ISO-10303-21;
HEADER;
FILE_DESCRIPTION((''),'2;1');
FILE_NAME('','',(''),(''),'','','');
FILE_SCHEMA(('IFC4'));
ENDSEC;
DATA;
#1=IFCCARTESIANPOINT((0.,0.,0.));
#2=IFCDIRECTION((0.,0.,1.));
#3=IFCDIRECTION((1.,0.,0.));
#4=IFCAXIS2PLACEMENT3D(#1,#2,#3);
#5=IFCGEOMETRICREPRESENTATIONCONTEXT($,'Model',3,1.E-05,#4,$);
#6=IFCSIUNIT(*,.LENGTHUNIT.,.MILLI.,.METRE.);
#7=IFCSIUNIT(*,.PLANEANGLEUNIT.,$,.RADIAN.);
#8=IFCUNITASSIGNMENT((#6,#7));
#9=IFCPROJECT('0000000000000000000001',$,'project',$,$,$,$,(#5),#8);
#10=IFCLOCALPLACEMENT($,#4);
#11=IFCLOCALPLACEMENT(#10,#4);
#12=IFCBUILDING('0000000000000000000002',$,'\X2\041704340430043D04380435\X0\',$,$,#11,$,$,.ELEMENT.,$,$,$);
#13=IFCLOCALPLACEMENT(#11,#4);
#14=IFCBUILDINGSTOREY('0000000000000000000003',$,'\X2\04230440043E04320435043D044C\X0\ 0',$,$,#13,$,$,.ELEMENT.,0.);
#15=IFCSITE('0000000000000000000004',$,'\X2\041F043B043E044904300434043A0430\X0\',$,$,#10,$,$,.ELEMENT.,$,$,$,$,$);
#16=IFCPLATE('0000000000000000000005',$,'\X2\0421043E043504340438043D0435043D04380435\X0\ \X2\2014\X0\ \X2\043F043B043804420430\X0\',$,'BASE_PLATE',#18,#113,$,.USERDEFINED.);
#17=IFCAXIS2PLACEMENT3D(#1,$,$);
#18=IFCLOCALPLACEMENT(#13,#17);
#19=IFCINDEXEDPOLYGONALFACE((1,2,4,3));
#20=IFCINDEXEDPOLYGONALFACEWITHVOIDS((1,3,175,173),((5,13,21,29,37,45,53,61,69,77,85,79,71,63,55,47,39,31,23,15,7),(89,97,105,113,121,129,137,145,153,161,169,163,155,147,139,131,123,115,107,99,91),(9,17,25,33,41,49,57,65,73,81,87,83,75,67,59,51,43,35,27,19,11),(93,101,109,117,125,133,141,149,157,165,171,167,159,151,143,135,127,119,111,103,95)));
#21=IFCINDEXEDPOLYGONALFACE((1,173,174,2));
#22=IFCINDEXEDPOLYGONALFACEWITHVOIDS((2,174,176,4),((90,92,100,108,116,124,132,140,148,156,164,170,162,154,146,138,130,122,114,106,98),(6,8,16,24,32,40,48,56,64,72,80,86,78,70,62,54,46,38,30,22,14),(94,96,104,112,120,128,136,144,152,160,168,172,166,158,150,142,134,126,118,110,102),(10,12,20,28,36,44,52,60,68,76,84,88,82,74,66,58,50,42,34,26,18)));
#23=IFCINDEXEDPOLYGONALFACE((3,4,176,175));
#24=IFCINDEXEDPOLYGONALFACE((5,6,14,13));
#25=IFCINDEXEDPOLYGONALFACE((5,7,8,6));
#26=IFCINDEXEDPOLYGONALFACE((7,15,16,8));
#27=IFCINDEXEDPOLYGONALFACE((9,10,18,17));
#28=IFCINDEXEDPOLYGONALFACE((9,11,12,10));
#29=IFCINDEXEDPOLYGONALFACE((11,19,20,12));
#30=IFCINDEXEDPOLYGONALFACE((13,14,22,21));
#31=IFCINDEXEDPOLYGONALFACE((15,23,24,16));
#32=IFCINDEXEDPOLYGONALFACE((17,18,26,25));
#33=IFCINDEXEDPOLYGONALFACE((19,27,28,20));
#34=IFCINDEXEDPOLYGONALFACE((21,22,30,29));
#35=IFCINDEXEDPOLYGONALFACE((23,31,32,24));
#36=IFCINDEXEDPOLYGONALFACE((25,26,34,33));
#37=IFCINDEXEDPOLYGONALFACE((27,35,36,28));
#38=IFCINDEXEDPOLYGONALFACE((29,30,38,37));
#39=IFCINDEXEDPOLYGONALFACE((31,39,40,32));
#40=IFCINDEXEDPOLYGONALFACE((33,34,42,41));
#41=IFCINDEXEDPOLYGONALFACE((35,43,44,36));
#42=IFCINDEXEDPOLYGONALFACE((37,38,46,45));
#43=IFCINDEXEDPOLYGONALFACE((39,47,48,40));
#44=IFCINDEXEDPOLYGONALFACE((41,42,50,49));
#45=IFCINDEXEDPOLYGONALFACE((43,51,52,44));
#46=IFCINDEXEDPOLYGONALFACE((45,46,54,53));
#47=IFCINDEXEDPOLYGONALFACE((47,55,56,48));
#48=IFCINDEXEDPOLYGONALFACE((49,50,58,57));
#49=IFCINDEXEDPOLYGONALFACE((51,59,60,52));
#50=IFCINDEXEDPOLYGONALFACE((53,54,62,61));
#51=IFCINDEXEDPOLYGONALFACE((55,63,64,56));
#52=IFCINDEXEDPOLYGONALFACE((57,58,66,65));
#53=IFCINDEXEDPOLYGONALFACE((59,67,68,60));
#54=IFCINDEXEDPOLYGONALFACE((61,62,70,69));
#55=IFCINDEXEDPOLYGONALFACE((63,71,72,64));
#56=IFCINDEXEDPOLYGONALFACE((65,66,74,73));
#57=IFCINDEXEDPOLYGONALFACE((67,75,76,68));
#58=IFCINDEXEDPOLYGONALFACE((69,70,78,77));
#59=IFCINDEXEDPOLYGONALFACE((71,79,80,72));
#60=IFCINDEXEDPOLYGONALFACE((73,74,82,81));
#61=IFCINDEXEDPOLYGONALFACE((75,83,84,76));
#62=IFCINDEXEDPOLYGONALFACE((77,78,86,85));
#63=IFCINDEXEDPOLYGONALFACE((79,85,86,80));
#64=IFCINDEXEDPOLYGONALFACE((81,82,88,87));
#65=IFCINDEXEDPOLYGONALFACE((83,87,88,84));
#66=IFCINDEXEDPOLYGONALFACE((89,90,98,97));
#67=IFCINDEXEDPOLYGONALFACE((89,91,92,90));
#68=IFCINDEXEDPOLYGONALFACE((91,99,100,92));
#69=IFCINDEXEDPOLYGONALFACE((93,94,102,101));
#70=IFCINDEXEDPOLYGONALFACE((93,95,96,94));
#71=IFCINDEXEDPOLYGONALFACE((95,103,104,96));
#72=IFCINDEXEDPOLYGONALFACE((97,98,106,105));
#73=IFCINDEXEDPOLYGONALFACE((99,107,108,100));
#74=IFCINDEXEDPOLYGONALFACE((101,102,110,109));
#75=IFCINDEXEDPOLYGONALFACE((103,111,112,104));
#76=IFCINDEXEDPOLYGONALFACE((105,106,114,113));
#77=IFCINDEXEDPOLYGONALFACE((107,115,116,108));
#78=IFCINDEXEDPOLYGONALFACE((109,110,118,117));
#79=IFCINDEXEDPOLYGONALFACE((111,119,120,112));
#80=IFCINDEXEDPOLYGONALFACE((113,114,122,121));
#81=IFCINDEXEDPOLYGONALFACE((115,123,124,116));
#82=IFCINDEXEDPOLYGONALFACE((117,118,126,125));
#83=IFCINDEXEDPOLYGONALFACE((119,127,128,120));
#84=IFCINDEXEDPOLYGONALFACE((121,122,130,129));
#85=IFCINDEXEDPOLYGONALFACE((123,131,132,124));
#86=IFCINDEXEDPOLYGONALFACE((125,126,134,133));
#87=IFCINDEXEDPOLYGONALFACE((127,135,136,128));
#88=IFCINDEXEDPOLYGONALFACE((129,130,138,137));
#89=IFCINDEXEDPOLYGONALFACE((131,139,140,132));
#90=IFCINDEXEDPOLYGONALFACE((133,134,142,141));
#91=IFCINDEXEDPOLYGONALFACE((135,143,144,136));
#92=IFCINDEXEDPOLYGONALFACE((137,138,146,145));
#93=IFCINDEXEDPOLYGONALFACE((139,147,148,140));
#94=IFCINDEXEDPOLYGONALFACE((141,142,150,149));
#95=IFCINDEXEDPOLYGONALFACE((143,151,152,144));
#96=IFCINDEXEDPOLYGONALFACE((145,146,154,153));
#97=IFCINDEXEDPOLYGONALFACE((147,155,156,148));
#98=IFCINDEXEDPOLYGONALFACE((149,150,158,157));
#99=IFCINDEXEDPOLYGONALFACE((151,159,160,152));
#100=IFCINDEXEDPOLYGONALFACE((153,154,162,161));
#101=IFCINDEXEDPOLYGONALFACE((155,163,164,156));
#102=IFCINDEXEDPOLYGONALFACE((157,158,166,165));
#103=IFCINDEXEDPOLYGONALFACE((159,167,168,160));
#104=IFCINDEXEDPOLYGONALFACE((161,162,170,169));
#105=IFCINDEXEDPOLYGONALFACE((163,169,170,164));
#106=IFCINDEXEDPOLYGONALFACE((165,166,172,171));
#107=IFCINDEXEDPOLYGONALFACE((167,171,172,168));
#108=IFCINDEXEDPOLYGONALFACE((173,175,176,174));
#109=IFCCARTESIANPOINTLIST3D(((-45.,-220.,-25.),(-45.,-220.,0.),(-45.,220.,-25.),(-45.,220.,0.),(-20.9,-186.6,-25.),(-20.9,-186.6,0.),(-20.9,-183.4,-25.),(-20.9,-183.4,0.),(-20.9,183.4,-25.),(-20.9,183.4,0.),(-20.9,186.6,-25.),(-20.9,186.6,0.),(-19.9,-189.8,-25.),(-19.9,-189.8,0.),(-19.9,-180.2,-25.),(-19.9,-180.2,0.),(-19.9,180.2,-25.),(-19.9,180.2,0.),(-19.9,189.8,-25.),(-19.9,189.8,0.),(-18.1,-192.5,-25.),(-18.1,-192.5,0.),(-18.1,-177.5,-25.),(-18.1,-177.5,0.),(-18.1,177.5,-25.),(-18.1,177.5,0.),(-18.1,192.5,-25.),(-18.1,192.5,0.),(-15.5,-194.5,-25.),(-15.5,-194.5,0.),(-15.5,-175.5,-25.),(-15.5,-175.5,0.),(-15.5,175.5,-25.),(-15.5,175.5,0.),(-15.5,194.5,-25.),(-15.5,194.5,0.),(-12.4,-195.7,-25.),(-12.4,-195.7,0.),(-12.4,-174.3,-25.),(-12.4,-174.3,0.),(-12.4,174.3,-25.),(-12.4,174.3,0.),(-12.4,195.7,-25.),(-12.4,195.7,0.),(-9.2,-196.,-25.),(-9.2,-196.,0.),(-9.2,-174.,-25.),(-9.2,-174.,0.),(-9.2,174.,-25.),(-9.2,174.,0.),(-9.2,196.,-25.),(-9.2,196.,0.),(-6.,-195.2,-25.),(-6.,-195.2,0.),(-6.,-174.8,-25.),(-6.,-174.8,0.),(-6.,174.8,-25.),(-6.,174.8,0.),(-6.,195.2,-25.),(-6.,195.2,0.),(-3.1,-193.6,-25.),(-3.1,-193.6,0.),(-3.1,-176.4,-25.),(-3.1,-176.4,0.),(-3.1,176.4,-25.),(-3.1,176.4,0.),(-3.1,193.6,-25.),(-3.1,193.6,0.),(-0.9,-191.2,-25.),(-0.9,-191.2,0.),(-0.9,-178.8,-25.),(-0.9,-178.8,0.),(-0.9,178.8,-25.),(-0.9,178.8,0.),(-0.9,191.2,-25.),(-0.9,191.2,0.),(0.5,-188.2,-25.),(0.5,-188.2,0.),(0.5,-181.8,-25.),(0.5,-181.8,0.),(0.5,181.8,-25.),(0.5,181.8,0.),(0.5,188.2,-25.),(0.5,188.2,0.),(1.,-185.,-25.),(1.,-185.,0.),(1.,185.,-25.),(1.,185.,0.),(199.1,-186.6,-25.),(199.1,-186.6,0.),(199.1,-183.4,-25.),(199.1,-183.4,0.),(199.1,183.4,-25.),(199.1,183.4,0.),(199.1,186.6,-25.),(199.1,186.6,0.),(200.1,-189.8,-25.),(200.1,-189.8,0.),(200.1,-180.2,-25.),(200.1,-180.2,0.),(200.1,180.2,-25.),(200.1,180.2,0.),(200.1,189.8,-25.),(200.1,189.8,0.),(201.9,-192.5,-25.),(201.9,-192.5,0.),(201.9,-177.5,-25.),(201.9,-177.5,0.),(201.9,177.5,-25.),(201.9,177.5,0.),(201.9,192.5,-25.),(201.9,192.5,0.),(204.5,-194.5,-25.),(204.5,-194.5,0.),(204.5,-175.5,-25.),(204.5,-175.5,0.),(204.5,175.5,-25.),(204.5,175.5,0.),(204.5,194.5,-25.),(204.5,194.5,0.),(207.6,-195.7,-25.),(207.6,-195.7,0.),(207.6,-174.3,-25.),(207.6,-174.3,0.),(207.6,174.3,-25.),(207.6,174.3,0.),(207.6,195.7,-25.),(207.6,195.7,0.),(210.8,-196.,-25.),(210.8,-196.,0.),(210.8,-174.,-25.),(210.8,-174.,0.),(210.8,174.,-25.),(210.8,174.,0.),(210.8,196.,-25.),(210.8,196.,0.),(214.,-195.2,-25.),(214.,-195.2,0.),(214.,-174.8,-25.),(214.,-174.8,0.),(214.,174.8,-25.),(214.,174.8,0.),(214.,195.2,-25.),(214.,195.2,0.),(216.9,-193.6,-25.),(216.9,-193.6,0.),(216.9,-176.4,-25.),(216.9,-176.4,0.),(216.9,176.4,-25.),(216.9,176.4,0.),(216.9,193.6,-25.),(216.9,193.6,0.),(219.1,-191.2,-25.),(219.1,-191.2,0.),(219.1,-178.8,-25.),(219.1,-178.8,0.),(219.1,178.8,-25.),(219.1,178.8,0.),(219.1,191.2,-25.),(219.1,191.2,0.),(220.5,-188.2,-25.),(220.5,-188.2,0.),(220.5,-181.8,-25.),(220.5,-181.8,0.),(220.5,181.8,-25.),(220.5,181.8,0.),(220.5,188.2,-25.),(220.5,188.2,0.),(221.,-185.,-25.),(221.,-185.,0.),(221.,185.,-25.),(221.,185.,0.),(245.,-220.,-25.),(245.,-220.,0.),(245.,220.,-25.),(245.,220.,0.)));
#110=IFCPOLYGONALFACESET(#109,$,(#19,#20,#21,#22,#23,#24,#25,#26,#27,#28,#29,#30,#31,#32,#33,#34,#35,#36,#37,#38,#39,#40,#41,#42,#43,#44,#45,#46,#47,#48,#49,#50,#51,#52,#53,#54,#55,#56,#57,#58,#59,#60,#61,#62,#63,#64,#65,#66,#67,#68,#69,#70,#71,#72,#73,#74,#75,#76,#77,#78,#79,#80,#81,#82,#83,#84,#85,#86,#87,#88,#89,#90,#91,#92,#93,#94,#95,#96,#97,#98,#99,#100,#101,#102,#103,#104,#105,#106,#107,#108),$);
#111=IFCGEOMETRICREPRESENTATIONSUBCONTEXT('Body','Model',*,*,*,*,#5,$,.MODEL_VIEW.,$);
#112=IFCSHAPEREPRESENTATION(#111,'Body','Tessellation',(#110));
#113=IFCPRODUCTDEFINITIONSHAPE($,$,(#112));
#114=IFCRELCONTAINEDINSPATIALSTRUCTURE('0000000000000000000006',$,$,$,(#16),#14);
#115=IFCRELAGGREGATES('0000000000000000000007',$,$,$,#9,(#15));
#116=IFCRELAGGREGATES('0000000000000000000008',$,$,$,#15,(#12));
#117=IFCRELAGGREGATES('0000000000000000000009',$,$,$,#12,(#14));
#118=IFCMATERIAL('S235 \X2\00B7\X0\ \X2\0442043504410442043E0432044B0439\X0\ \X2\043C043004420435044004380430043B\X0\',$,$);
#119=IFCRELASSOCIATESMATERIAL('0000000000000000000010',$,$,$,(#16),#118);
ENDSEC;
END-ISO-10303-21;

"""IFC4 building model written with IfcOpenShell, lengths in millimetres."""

from ifc_helpers import new_model, si_unit, frame, origin_with_axes, place, context, subcontext, project, spatial, polyline, circle, outline, extrude, material, element, save


model = new_model("IFC4")

# Units and contexts
model_context = context("Model", 3, precision=1e-05, world=origin_with_axes())
body_context = subcontext(model_context, "Body", "Model", "MODEL_VIEW")
ifc_project = project(units=[si_unit("LENGTHUNIT", "METRE", prefix="MILLI"), si_unit("PLANEANGLEUNIT", "RADIAN")], contexts=[model_context])

# Site, building, storey
site_placement = place(None, origin_with_axes())
site = spatial("IfcSite", under=ifc_project, at=site_placement, Name="Площадка", CompositionType="ELEMENT")
building_placement = place(site_placement, origin_with_axes())
building = spatial("IfcBuilding", under=site, at=building_placement, Name="Здание", CompositionType="ELEMENT")
storey_placement = place(building_placement, origin_with_axes())
storey = spatial("IfcBuildingStorey", under=building, at=storey_placement, Name="Уровень 0", CompositionType="ELEMENT", Elevation=0.0)

# Shared definitions
ifc_material = material(Name="S235 · тестовый материал")

# Plate, openings
plate_1_placement = place(storey_placement, frame((-45.0, -220.0, -25.0), z_axis=(0.0, 0.0, 1.0), x_axis=(1.0, 0.0, 0.0)))
plate_1 = element("IfcPlate", 1, at=plate_1_placement, inside=storey, material=ifc_material, Name="Соединение — плита", ObjectType="BASE_PLATE", PredefinedType="USERDEFINED", context=body_context, shape_type="SweptSolid", body=[
    extrude(outline(polyline([(0.0, 0.0), (290.0, 0.0), (290.0, 440.0), (0.0, 440.0), (0.0, 0.0)])), origin_with_axes(), (0.0, 0.0, 1.0), 25.0),
])
opening_1_placement = place(plate_1_placement, frame((35.0, 35.0, -1.0), z_axis=(0.0, 0.0, 1.0), x_axis=(1.0, 0.0, 0.0)))
element("IfcOpeningElement", 2, at=opening_1_placement, cuts=plate_1, PredefinedType="OPENING", context=body_context, shape_type="SweptSolid", body=[
    extrude(circle(Radius=11.0), origin_with_axes(), (0.0, 0.0, 1.0), 27.0),
])
opening_2_placement = place(plate_1_placement, frame((255.0, 35.0, -1.0), z_axis=(0.0, 0.0, 1.0), x_axis=(1.0, 0.0, 0.0)))
element("IfcOpeningElement", 3, at=opening_2_placement, cuts=plate_1, PredefinedType="OPENING", context=body_context, shape_type="SweptSolid", body=[
    extrude(circle(Radius=11.0), origin_with_axes(), (0.0, 0.0, 1.0), 27.0),
])
opening_3_placement = place(plate_1_placement, frame((35.0, 405.0, -1.0), z_axis=(0.0, 0.0, 1.0), x_axis=(1.0, 0.0, 0.0)))
element("IfcOpeningElement", 4, at=opening_3_placement, cuts=plate_1, PredefinedType="OPENING", context=body_context, shape_type="SweptSolid", body=[
    extrude(circle(Radius=11.0), origin_with_axes(), (0.0, 0.0, 1.0), 27.0),
])
opening_4_placement = place(plate_1_placement, frame((255.0, 405.0, -1.0), z_axis=(0.0, 0.0, 1.0), x_axis=(1.0, 0.0, 0.0)))
element("IfcOpeningElement", 5, at=opening_4_placement, cuts=plate_1, PredefinedType="OPENING", context=body_context, shape_type="SweptSolid", body=[
    extrude(circle(Radius=11.0), origin_with_axes(), (0.0, 0.0, 1.0), 27.0),
])

save(model, "model.ifc")
